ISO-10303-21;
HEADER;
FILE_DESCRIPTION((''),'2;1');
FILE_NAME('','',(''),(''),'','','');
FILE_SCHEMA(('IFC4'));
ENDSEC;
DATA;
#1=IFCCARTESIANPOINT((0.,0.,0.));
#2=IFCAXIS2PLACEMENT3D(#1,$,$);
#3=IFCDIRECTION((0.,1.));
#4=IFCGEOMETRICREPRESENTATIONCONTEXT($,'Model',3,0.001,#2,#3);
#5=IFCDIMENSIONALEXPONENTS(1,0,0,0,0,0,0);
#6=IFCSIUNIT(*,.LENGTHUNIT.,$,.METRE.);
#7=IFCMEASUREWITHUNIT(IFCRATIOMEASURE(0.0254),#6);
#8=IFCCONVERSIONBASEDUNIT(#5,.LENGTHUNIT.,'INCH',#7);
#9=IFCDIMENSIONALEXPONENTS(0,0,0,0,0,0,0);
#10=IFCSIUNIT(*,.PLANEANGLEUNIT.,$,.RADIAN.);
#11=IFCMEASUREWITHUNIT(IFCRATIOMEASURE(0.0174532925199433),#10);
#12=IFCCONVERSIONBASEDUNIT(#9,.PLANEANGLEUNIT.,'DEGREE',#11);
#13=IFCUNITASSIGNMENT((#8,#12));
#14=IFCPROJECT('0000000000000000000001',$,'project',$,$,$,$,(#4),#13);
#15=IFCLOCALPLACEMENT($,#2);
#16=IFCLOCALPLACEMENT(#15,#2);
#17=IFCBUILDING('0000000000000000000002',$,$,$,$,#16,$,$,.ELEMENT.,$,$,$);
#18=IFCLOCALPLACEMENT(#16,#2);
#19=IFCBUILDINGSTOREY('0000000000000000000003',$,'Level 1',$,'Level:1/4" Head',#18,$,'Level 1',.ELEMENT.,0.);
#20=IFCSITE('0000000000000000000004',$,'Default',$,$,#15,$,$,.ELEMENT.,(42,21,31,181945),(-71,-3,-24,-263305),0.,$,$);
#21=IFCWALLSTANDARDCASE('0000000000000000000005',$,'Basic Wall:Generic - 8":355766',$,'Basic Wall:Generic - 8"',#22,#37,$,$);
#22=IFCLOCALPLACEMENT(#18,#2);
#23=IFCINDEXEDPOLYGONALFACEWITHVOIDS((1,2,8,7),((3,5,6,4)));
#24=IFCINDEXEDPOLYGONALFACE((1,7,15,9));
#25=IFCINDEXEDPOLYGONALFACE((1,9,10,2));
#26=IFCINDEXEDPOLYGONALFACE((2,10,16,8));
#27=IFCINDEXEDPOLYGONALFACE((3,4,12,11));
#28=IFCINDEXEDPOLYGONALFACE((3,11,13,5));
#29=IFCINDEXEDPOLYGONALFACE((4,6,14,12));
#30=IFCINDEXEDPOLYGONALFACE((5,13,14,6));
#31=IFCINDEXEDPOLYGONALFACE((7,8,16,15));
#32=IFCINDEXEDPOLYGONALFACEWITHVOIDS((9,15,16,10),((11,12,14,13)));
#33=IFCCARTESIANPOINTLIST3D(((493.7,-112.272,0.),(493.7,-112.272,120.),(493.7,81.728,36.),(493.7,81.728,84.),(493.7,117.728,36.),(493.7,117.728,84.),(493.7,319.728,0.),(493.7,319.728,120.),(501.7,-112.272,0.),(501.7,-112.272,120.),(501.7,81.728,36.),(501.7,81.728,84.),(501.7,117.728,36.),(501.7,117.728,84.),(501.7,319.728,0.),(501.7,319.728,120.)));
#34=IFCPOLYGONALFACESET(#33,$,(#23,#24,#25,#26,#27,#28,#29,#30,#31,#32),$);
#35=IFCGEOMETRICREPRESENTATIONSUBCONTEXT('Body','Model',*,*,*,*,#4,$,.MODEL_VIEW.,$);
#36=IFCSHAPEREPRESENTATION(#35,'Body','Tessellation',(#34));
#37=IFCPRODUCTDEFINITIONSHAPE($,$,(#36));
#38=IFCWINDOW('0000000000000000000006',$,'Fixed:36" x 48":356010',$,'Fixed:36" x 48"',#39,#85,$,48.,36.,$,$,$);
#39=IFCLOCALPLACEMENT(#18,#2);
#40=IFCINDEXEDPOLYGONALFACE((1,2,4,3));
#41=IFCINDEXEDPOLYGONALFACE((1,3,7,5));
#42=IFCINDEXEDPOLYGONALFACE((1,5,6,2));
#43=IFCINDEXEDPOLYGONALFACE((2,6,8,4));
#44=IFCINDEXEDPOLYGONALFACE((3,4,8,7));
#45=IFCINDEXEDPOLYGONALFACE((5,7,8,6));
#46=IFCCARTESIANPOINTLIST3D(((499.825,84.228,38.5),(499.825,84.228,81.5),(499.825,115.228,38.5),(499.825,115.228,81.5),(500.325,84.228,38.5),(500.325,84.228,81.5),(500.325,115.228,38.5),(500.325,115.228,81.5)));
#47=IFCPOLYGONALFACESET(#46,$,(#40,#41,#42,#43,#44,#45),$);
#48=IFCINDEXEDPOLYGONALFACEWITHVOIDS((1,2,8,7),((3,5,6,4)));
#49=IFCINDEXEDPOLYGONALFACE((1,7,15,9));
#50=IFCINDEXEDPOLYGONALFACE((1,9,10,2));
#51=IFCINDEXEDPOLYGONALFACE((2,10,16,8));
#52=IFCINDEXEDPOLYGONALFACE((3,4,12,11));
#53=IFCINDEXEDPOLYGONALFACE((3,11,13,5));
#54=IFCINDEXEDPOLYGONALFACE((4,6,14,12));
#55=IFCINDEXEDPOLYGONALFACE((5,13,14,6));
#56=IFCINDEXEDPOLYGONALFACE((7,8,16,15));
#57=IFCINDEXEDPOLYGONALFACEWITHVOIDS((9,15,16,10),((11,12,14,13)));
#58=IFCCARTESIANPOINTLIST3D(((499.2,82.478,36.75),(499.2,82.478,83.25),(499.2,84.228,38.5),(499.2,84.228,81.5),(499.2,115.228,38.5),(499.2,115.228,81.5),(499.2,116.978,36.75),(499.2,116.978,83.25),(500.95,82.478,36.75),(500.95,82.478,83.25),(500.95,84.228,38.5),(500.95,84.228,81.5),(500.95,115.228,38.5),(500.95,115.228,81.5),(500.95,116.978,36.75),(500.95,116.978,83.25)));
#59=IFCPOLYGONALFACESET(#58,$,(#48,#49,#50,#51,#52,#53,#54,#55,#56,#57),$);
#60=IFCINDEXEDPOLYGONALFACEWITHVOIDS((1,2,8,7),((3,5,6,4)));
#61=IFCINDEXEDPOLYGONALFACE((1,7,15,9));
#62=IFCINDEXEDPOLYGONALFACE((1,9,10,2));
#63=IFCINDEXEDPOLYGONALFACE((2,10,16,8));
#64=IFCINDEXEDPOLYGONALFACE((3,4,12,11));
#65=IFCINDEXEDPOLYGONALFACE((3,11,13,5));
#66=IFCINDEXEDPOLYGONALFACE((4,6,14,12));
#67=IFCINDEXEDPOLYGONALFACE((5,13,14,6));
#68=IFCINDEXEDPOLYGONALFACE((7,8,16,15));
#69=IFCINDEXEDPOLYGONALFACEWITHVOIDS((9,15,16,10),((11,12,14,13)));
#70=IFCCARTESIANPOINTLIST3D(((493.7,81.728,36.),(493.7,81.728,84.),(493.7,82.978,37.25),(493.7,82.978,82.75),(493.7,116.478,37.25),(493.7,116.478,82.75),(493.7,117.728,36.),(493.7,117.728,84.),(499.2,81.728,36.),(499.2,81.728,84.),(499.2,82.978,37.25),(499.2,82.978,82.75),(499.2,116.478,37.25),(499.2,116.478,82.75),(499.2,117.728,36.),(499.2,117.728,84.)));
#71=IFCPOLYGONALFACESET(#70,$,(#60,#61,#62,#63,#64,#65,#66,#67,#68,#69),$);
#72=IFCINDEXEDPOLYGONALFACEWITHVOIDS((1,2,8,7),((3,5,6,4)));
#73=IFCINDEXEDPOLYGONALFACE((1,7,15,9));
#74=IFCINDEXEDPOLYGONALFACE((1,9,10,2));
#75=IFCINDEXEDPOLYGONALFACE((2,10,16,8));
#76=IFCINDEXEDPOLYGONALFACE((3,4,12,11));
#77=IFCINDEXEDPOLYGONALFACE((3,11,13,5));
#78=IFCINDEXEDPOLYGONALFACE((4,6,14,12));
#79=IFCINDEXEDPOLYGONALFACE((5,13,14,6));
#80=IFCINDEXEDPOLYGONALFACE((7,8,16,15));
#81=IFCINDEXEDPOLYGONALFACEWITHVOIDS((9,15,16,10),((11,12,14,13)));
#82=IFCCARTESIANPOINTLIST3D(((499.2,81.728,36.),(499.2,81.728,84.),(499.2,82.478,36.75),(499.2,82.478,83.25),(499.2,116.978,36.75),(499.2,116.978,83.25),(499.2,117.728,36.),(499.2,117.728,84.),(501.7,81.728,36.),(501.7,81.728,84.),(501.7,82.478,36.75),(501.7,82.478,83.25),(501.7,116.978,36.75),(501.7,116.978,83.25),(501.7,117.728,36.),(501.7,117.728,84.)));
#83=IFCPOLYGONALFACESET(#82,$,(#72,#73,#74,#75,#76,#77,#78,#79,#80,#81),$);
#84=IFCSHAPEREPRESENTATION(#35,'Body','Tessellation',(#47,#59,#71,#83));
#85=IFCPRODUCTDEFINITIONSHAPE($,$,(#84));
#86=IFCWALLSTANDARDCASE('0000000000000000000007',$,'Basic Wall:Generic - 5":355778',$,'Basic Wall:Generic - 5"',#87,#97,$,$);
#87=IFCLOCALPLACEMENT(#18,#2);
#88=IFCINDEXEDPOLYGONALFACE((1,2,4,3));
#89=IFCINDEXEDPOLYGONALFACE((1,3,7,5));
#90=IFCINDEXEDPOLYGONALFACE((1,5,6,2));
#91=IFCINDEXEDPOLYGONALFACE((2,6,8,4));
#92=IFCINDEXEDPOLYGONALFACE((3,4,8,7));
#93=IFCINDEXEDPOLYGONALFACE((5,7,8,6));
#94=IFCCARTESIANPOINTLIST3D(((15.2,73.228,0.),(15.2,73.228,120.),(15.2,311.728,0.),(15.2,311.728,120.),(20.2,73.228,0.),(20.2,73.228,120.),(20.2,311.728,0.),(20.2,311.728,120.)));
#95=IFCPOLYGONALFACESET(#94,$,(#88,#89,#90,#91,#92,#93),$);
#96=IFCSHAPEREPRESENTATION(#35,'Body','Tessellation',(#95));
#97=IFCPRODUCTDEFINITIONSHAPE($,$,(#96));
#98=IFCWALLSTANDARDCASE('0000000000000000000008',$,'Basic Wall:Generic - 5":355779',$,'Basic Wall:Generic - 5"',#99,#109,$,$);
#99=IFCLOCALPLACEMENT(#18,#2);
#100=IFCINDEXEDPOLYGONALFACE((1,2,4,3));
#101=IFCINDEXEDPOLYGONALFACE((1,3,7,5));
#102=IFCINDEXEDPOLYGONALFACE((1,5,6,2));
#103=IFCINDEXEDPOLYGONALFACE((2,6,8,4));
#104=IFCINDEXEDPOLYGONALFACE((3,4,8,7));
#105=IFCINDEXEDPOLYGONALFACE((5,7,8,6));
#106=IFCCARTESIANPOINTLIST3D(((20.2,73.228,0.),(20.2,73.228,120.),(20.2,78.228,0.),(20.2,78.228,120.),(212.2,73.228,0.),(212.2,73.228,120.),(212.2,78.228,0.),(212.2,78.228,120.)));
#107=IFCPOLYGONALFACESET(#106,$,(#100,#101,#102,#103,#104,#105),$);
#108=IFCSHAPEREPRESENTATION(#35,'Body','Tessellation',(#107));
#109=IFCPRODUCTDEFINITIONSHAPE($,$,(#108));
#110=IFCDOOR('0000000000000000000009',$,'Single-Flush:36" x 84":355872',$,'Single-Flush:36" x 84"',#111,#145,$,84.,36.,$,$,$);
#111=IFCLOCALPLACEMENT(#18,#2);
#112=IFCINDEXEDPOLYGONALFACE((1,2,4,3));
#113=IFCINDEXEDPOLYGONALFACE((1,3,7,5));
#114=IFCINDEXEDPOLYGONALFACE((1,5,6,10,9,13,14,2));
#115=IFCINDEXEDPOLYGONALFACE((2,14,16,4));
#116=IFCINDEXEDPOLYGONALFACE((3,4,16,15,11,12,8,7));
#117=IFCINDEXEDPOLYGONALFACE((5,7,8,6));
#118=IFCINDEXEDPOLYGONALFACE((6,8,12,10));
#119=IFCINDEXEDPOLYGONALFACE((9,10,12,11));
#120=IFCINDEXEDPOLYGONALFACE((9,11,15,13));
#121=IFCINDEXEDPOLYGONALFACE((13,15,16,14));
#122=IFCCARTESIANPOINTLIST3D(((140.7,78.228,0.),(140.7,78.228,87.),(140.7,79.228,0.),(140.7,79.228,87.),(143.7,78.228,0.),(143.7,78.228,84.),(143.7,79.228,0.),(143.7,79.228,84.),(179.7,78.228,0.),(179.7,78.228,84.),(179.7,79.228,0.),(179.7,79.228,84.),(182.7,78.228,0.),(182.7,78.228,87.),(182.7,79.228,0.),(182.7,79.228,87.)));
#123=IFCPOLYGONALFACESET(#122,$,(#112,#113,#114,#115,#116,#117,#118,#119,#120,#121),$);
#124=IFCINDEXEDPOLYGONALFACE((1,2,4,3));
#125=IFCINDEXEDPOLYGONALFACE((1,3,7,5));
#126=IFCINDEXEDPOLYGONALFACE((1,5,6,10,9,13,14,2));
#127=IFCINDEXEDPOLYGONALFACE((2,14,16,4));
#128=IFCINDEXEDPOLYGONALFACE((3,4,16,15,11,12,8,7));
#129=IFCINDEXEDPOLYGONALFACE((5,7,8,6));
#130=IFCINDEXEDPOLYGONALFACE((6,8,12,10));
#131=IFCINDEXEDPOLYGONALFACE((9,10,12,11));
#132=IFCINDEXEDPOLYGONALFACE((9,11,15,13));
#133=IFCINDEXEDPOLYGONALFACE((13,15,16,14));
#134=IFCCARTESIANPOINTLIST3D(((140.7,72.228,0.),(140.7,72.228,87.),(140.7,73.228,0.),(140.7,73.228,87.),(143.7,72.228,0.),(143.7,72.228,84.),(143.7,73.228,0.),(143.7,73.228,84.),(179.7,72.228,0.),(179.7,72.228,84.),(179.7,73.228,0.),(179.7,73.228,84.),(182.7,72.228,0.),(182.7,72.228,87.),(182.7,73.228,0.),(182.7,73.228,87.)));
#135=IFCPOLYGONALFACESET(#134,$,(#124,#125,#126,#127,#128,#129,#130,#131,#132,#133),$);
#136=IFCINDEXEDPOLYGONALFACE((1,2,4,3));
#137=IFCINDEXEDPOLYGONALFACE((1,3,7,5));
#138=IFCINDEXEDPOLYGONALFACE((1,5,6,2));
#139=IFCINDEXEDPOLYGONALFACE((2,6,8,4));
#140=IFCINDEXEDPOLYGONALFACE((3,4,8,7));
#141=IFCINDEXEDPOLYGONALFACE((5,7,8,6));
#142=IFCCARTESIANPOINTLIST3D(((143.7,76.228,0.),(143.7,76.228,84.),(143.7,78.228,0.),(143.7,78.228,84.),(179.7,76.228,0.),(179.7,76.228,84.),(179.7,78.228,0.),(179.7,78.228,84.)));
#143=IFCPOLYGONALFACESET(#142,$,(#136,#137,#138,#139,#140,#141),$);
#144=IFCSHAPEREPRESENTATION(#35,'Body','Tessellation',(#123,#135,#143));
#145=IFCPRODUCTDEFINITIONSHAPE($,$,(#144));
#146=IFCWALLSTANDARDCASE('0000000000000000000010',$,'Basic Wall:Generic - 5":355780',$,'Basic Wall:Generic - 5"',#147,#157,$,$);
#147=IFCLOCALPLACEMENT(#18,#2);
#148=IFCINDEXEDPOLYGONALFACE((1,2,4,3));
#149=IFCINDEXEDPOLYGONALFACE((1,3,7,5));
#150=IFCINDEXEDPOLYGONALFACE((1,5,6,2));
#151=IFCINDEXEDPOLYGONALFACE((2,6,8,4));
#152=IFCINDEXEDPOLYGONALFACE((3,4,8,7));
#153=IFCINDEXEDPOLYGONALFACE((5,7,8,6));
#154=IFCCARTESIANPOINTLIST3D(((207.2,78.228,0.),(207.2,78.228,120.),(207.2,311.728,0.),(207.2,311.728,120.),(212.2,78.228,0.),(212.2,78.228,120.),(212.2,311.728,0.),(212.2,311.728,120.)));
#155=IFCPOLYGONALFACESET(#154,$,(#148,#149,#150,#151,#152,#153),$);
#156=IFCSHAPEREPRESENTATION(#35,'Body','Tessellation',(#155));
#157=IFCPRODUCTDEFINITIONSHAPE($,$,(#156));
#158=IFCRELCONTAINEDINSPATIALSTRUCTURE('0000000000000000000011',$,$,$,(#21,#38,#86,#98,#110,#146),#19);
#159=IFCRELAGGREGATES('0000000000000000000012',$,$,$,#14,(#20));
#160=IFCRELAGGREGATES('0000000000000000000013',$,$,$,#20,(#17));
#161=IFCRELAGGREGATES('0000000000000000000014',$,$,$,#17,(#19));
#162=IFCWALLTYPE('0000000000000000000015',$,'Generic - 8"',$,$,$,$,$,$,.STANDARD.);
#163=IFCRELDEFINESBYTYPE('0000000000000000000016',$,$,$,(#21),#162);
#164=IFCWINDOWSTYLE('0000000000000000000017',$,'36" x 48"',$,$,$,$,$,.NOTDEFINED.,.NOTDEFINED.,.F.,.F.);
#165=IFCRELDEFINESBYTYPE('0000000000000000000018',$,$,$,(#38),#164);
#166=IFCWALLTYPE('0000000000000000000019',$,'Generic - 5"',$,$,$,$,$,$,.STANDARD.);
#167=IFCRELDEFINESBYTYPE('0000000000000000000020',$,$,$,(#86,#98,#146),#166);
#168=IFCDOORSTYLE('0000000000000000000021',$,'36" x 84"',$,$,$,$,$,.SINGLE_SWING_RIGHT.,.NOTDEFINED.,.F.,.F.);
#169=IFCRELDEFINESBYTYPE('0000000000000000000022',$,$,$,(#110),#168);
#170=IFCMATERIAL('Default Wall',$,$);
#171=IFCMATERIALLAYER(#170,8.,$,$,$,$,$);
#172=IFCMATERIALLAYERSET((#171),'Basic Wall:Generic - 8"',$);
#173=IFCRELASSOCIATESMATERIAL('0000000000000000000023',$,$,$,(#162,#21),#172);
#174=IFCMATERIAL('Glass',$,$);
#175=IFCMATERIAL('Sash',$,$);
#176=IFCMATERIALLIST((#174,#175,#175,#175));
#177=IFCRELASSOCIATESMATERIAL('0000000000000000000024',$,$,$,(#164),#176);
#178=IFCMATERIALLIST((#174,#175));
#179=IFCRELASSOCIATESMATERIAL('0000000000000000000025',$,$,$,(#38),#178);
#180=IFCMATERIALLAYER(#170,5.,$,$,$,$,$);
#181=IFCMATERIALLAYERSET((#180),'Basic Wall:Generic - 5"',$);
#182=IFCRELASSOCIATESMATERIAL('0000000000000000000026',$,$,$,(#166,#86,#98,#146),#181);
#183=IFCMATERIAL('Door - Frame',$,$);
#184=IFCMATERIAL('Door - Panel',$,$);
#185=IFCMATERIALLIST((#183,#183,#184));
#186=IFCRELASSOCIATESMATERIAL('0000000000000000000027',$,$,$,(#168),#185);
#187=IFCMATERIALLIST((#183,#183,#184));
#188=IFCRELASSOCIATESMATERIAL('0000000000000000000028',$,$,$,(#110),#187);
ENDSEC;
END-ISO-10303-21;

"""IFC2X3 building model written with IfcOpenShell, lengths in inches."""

from ifc_helpers import new_model, entity, si_unit, converted_unit, direction, frame, frame_2d, origin, place, context, subcontext, project, spatial, polyline, rectangle, outline, extrude, source, transform, mapped, material, material_list, layer, layer_set, layer_usage, type_object, type_shapes, element, fill, save


model = new_model("IFC2X3")

# Units and contexts
model_context = context("Model", 3, precision=0.001, world=origin(), true_north=direction((0.0, 1.0)))
body_context = subcontext(model_context, "Body", "Model", "MODEL_VIEW")
ifc_project = project(units=[converted_unit("LENGTHUNIT", "INCH", entity("IfcRatioMeasure", 0.0254), si_unit("LENGTHUNIT", "METRE"), dimensions=[1, 0, 0, 0, 0, 0, 0]), converted_unit("PLANEANGLEUNIT", "DEGREE", entity("IfcRatioMeasure", 0.0174532925199433), si_unit("PLANEANGLEUNIT", "RADIAN"), dimensions=[0, 0, 0, 0, 0, 0, 0])], contexts=[model_context])

# Site, building, storey
site_placement = place(None, origin())
site = spatial("IfcSite", under=ifc_project, at=site_placement, Name="Default", CompositionType="ELEMENT", RefLatitude=(42, 21, 31, 181945), RefLongitude=(-71, -3, -24, -263305), RefElevation=0.0)
building_placement = place(site_placement, origin())
building = spatial("IfcBuilding", under=site, at=building_placement, CompositionType="ELEMENT")
storey_placement = place(building_placement, origin())
storey = spatial("IfcBuildingStorey", under=building, at=storey_placement, Name="Level 1", ObjectType="Level:1/4\" Head", LongName="Level 1", CompositionType="ELEMENT", Elevation=0.0)

# Shared definitions
ifc_material_1 = material(Name="Default Wall")
ifc_layer_1 = layer(ifc_material_1, 8.0)
ifc_layer_set_1 = layer_set([ifc_layer_1], Name="Basic Wall:Generic - 8\"")
wall_type_1 = type_object("IfcWallType", Name="Generic - 8\"", PredefinedType="STANDARD", material=ifc_layer_set_1)
ifc_material_2 = material(Name="Glass")
ifc_material_3 = material(Name="Sash")
ifc_material_list_1 = material_list([ifc_material_2, ifc_material_3, ifc_material_3, ifc_material_3])
window_style = type_object("IfcWindowStyle", Name="36\" x 48\"", ConstructionType="NOTDEFINED", OperationType="NOTDEFINED", ParameterTakesPrecedence=False, Sizeable=False, material=ifc_material_list_1)
shared_shape_1 = source(origin(), body_context, "Body", "SweptSolid", [
    extrude(rectangle(XDim=0.5, YDim=31.0, at=frame_2d((0.0, 0.0), x_axis=(1.0, 0.0))), frame((18.0, 6.375, 2.5), z_axis=(0.0, 0.0, 1.0), x_axis=(0.0, 1.0, 0.0)), (0.0, 0.0, 1.0), 43.0),
    extrude(outline(polyline([(-17.25, -23.25), (17.25, -23.25), (17.25, 23.25), (-17.25, 23.25), (-17.25, -23.25)]), holes=[polyline([(-15.5, -21.5), (-15.5, 21.5), (15.5, 21.5), (15.5, -21.5), (-15.5, -21.5)])]), frame((18.0, 5.5, 24.0), z_axis=(0.0, 1.0, 0.0), x_axis=(1.0, 0.0, 0.0)), (0.0, 0.0, 1.0), 1.75),
    extrude(outline(polyline([(-18.0, -24.0), (18.0, -24.0), (18.0, 24.0), (-18.0, 24.0), (-18.0, -24.0)]), holes=[polyline([(-16.75, -22.75), (-16.75, 22.75), (16.75, 22.75), (16.75, -22.75), (-16.75, -22.75)])]), frame((18.0, 0.0, 24.0), z_axis=(0.0, 1.0, 0.0), x_axis=(1.0, 0.0, 0.0)), (0.0, 0.0, 1.0), 5.5),
    extrude(outline(polyline([(-24.0, -18.0), (24.0, -18.0), (24.0, 18.0), (-24.0, 18.0), (-24.0, -18.0)]), holes=[polyline([(-23.25, -17.25), (-23.25, 17.25), (23.25, 17.25), (23.25, -17.25), (-23.25, -17.25)])]), frame((18.0, 5.5, 24.0), z_axis=(0.0, 1.0, 0.0), x_axis=(0.0, 0.0, -1.0)), (0.0, 0.0, 1.0), 2.5),
])
type_shapes(window_style, [shared_shape_1])

# Shared definitions
ifc_material_4 = material(Name="Door - Frame")
ifc_material_5 = material(Name="Door - Panel")

# Wall, opening, window
ifc_layer_usage_1 = layer_usage(ifc_layer_set_1, "AXIS2", "NEGATIVE", 4.0)
wall_1_placement = place(storey_placement, frame((497.7, 319.728, 0.0), z_axis=(0.0, 0.0, 1.0), x_axis=(0.0, -1.0, 0.0)))
wall_1 = element("IfcWallStandardCase", 1, at=wall_1_placement, inside=storey, type_object=wall_type_1, material=ifc_layer_usage_1, Name="Basic Wall:Generic - 8\":355766", ObjectType="Basic Wall:Generic - 8\"", context=body_context, shape_type="SweptSolid", body=[
    extrude(rectangle(XDim=432.0, YDim=8.0, at=frame_2d((216.0, 0.0), x_axis=(-1.0, 0.0))), origin(), (0.0, 0.0, 1.0), 120.0),
])
opening_1_placement = place(wall_1_placement, frame((238.0, 4.0, 36.0)))
opening_1 = element("IfcOpeningElement", 2, at=opening_1_placement, cuts=wall_1, ObjectType="Opening", context=body_context, shape_type="SweptSolid", body=[
    extrude(rectangle(XDim=48.0, YDim=36.0, at=frame_2d((24.0, 18.0), x_axis=(-1.0, 0.0))), frame((0.0, 0.0, 0.0), z_axis=(0.0, -1.0, 0.0), x_axis=(0.0, 0.0, 1.0)), (0.0, 0.0, 1.0), 8.0),
])
ifc_material_list_2 = material_list([ifc_material_2, ifc_material_3])
window_1_placement = place(opening_1_placement, frame((-36.0, -8.0, 0.0)))
window_1 = element("IfcWindow", 3, at=window_1_placement, inside=storey, type_object=window_style, material=ifc_material_list_2, Name="Fixed:36\" x 48\":356010", ObjectType="Fixed:36\" x 48\"", OverallHeight=48.0, OverallWidth=36.0, context=body_context, shape_type="MappedRepresentation", body=[
    mapped(shared_shape_1, transform((0.0, 0.0, 0.0), scale=1.0)),
])
fill(opening_1, window_1)

# Wall
ifc_layer_2 = layer(ifc_material_1, 5.0)
ifc_layer_set_2 = layer_set([ifc_layer_2], Name="Basic Wall:Generic - 5\"")
ifc_layer_usage_2 = layer_usage(ifc_layer_set_2, "AXIS2", "NEGATIVE", 2.5)
wall_type_2 = type_object("IfcWallType", Name="Generic - 5\"", PredefinedType="STANDARD", material=ifc_layer_set_2)
wall_2_placement = place(storey_placement, frame((17.7, 73.228, 0.0), z_axis=(0.0, 0.0, 1.0), x_axis=(0.0, 1.0, 0.0)))
element("IfcWallStandardCase", 4, at=wall_2_placement, inside=storey, type_object=wall_type_2, material=ifc_layer_usage_2, Name="Basic Wall:Generic - 5\":355778", ObjectType="Basic Wall:Generic - 5\"", context=body_context, shape_type="SweptSolid", body=[
    extrude(rectangle(XDim=238.5, YDim=5.0, at=frame_2d((119.25, 0.0), x_axis=(-1.0, 0.0))), origin(), (0.0, 0.0, 1.0), 120.0),
])

# Wall, opening, door
ifc_layer_usage_3 = layer_usage(ifc_layer_set_2, "AXIS2", "NEGATIVE", 2.5)
wall_3_placement = place(storey_placement, frame((212.2, 75.728, 0.0), z_axis=(0.0, 0.0, 1.0), x_axis=(-1.0, 0.0, 0.0)))
wall_3 = element("IfcWallStandardCase", 5, at=wall_3_placement, inside=storey, type_object=wall_type_2, material=ifc_layer_usage_3, Name="Basic Wall:Generic - 5\":355779", ObjectType="Basic Wall:Generic - 5\"", context=body_context, shape_type="SweptSolid", body=[
    extrude(rectangle(XDim=192.0, YDim=5.0, at=frame_2d((96.0, 0.0), x_axis=(-1.0, 0.0))), origin(), (0.0, 0.0, 1.0), 120.0),
])
opening_2_placement = place(wall_3_placement, frame((68.5, 7.5, 0.0)))
opening_2 = element("IfcOpeningElement", 6, at=opening_2_placement, cuts=wall_3, ObjectType="Opening", context=body_context, shape_type="SweptSolid", body=[
    extrude(rectangle(XDim=36.0, YDim=84.0, at=frame_2d((42.0, 18.0), x_axis=(0.0, 1.0))), frame((0.0, 0.0, 0.0), z_axis=(0.0, -1.0, 0.0), x_axis=(0.0, 0.0, 1.0)), (0.0, 0.0, 1.0), 5.0),
])
ifc_material_list_3 = material_list([ifc_material_4, ifc_material_4, ifc_material_5])
ifc_material_list_4 = material_list([ifc_material_4, ifc_material_4, ifc_material_5])
door_style_1 = type_object("IfcDoorStyle", Name="36\" x 84\"", ConstructionType="NOTDEFINED", OperationType="SINGLE_SWING_RIGHT", ParameterTakesPrecedence=False, Sizeable=False, material=ifc_material_list_4)
shared_shape_2 = source(origin(), body_context, "Body", "SweptSolid", [
    extrude(outline(polyline([(-21.0, -44.25), (21.0, -44.25), (21.0, 42.75), (18.0, 42.75), (18.0, -41.25), (-18.0, -41.25), (-18.0, 42.75), (-21.0, 42.75), (-21.0, -44.25)])), frame((18.0, 5.0, 42.75), z_axis=(0.0, 1.0, 0.0), x_axis=(1.0, 0.0, 0.0)), (0.0, 0.0, 1.0), 1.0),
    extrude(outline(polyline([(-44.25, -21.0), (42.75, -21.0), (42.75, -18.0), (-41.25, -18.0), (-41.25, 18.0), (42.75, 18.0), (42.75, 21.0), (-44.25, 21.0), (-44.25, -21.0)])), frame((18.0, -1.0, 42.75), z_axis=(0.0, 1.0, 0.0), x_axis=(0.0, 0.0, -1.0)), (0.0, 0.0, 1.0), 1.0),
    extrude(rectangle(XDim=2.0, YDim=36.0, at=frame_2d((0.0, 0.0), x_axis=(1.0, 0.0))), frame((18.0, 4.0, 0.0), z_axis=(0.0, 0.0, 1.0), x_axis=(0.0, 1.0, 0.0)), (0.0, 0.0, 1.0), 84.0),
])
type_shapes(door_style_1, [shared_shape_2])
door_1_placement = place(opening_2_placement, frame((0.0, -5.0, 0.0), z_axis=(0.0, 0.0, 1.0), x_axis=(-1.0, 0.0, 0.0)))
door_1 = element("IfcDoor", 7, at=door_1_placement, inside=storey, type_object=door_style_1, material=ifc_material_list_3, Name="Single-Flush:36\" x 84\":355872", ObjectType="Single-Flush:36\" x 84\"", OverallHeight=84.0, OverallWidth=36.0, context=body_context, shape_type="MappedRepresentation", body=[
    mapped(shared_shape_2, transform((0.0, 0.0, 0.0), scale=1.0)),
])
fill(opening_2, door_1)

# Wall
ifc_layer_usage_4 = layer_usage(ifc_layer_set_2, "AXIS2", "NEGATIVE", 2.5)
wall_4_placement = place(storey_placement, frame((209.7, 311.728, 0.0), z_axis=(0.0, 0.0, 1.0), x_axis=(0.0, -1.0, 0.0)))
element("IfcWallStandardCase", 8, at=wall_4_placement, inside=storey, type_object=wall_type_2, material=ifc_layer_usage_4, Name="Basic Wall:Generic - 5\":355780", ObjectType="Basic Wall:Generic - 5\"", context=body_context, shape_type="SweptSolid", body=[
    extrude(rectangle(XDim=233.5, YDim=5.0, at=frame_2d((116.75, 0.0), x_axis=(-1.0, 0.0))), origin(), (0.0, 0.0, 1.0), 120.0),
])

save(model, "model.ifc")
